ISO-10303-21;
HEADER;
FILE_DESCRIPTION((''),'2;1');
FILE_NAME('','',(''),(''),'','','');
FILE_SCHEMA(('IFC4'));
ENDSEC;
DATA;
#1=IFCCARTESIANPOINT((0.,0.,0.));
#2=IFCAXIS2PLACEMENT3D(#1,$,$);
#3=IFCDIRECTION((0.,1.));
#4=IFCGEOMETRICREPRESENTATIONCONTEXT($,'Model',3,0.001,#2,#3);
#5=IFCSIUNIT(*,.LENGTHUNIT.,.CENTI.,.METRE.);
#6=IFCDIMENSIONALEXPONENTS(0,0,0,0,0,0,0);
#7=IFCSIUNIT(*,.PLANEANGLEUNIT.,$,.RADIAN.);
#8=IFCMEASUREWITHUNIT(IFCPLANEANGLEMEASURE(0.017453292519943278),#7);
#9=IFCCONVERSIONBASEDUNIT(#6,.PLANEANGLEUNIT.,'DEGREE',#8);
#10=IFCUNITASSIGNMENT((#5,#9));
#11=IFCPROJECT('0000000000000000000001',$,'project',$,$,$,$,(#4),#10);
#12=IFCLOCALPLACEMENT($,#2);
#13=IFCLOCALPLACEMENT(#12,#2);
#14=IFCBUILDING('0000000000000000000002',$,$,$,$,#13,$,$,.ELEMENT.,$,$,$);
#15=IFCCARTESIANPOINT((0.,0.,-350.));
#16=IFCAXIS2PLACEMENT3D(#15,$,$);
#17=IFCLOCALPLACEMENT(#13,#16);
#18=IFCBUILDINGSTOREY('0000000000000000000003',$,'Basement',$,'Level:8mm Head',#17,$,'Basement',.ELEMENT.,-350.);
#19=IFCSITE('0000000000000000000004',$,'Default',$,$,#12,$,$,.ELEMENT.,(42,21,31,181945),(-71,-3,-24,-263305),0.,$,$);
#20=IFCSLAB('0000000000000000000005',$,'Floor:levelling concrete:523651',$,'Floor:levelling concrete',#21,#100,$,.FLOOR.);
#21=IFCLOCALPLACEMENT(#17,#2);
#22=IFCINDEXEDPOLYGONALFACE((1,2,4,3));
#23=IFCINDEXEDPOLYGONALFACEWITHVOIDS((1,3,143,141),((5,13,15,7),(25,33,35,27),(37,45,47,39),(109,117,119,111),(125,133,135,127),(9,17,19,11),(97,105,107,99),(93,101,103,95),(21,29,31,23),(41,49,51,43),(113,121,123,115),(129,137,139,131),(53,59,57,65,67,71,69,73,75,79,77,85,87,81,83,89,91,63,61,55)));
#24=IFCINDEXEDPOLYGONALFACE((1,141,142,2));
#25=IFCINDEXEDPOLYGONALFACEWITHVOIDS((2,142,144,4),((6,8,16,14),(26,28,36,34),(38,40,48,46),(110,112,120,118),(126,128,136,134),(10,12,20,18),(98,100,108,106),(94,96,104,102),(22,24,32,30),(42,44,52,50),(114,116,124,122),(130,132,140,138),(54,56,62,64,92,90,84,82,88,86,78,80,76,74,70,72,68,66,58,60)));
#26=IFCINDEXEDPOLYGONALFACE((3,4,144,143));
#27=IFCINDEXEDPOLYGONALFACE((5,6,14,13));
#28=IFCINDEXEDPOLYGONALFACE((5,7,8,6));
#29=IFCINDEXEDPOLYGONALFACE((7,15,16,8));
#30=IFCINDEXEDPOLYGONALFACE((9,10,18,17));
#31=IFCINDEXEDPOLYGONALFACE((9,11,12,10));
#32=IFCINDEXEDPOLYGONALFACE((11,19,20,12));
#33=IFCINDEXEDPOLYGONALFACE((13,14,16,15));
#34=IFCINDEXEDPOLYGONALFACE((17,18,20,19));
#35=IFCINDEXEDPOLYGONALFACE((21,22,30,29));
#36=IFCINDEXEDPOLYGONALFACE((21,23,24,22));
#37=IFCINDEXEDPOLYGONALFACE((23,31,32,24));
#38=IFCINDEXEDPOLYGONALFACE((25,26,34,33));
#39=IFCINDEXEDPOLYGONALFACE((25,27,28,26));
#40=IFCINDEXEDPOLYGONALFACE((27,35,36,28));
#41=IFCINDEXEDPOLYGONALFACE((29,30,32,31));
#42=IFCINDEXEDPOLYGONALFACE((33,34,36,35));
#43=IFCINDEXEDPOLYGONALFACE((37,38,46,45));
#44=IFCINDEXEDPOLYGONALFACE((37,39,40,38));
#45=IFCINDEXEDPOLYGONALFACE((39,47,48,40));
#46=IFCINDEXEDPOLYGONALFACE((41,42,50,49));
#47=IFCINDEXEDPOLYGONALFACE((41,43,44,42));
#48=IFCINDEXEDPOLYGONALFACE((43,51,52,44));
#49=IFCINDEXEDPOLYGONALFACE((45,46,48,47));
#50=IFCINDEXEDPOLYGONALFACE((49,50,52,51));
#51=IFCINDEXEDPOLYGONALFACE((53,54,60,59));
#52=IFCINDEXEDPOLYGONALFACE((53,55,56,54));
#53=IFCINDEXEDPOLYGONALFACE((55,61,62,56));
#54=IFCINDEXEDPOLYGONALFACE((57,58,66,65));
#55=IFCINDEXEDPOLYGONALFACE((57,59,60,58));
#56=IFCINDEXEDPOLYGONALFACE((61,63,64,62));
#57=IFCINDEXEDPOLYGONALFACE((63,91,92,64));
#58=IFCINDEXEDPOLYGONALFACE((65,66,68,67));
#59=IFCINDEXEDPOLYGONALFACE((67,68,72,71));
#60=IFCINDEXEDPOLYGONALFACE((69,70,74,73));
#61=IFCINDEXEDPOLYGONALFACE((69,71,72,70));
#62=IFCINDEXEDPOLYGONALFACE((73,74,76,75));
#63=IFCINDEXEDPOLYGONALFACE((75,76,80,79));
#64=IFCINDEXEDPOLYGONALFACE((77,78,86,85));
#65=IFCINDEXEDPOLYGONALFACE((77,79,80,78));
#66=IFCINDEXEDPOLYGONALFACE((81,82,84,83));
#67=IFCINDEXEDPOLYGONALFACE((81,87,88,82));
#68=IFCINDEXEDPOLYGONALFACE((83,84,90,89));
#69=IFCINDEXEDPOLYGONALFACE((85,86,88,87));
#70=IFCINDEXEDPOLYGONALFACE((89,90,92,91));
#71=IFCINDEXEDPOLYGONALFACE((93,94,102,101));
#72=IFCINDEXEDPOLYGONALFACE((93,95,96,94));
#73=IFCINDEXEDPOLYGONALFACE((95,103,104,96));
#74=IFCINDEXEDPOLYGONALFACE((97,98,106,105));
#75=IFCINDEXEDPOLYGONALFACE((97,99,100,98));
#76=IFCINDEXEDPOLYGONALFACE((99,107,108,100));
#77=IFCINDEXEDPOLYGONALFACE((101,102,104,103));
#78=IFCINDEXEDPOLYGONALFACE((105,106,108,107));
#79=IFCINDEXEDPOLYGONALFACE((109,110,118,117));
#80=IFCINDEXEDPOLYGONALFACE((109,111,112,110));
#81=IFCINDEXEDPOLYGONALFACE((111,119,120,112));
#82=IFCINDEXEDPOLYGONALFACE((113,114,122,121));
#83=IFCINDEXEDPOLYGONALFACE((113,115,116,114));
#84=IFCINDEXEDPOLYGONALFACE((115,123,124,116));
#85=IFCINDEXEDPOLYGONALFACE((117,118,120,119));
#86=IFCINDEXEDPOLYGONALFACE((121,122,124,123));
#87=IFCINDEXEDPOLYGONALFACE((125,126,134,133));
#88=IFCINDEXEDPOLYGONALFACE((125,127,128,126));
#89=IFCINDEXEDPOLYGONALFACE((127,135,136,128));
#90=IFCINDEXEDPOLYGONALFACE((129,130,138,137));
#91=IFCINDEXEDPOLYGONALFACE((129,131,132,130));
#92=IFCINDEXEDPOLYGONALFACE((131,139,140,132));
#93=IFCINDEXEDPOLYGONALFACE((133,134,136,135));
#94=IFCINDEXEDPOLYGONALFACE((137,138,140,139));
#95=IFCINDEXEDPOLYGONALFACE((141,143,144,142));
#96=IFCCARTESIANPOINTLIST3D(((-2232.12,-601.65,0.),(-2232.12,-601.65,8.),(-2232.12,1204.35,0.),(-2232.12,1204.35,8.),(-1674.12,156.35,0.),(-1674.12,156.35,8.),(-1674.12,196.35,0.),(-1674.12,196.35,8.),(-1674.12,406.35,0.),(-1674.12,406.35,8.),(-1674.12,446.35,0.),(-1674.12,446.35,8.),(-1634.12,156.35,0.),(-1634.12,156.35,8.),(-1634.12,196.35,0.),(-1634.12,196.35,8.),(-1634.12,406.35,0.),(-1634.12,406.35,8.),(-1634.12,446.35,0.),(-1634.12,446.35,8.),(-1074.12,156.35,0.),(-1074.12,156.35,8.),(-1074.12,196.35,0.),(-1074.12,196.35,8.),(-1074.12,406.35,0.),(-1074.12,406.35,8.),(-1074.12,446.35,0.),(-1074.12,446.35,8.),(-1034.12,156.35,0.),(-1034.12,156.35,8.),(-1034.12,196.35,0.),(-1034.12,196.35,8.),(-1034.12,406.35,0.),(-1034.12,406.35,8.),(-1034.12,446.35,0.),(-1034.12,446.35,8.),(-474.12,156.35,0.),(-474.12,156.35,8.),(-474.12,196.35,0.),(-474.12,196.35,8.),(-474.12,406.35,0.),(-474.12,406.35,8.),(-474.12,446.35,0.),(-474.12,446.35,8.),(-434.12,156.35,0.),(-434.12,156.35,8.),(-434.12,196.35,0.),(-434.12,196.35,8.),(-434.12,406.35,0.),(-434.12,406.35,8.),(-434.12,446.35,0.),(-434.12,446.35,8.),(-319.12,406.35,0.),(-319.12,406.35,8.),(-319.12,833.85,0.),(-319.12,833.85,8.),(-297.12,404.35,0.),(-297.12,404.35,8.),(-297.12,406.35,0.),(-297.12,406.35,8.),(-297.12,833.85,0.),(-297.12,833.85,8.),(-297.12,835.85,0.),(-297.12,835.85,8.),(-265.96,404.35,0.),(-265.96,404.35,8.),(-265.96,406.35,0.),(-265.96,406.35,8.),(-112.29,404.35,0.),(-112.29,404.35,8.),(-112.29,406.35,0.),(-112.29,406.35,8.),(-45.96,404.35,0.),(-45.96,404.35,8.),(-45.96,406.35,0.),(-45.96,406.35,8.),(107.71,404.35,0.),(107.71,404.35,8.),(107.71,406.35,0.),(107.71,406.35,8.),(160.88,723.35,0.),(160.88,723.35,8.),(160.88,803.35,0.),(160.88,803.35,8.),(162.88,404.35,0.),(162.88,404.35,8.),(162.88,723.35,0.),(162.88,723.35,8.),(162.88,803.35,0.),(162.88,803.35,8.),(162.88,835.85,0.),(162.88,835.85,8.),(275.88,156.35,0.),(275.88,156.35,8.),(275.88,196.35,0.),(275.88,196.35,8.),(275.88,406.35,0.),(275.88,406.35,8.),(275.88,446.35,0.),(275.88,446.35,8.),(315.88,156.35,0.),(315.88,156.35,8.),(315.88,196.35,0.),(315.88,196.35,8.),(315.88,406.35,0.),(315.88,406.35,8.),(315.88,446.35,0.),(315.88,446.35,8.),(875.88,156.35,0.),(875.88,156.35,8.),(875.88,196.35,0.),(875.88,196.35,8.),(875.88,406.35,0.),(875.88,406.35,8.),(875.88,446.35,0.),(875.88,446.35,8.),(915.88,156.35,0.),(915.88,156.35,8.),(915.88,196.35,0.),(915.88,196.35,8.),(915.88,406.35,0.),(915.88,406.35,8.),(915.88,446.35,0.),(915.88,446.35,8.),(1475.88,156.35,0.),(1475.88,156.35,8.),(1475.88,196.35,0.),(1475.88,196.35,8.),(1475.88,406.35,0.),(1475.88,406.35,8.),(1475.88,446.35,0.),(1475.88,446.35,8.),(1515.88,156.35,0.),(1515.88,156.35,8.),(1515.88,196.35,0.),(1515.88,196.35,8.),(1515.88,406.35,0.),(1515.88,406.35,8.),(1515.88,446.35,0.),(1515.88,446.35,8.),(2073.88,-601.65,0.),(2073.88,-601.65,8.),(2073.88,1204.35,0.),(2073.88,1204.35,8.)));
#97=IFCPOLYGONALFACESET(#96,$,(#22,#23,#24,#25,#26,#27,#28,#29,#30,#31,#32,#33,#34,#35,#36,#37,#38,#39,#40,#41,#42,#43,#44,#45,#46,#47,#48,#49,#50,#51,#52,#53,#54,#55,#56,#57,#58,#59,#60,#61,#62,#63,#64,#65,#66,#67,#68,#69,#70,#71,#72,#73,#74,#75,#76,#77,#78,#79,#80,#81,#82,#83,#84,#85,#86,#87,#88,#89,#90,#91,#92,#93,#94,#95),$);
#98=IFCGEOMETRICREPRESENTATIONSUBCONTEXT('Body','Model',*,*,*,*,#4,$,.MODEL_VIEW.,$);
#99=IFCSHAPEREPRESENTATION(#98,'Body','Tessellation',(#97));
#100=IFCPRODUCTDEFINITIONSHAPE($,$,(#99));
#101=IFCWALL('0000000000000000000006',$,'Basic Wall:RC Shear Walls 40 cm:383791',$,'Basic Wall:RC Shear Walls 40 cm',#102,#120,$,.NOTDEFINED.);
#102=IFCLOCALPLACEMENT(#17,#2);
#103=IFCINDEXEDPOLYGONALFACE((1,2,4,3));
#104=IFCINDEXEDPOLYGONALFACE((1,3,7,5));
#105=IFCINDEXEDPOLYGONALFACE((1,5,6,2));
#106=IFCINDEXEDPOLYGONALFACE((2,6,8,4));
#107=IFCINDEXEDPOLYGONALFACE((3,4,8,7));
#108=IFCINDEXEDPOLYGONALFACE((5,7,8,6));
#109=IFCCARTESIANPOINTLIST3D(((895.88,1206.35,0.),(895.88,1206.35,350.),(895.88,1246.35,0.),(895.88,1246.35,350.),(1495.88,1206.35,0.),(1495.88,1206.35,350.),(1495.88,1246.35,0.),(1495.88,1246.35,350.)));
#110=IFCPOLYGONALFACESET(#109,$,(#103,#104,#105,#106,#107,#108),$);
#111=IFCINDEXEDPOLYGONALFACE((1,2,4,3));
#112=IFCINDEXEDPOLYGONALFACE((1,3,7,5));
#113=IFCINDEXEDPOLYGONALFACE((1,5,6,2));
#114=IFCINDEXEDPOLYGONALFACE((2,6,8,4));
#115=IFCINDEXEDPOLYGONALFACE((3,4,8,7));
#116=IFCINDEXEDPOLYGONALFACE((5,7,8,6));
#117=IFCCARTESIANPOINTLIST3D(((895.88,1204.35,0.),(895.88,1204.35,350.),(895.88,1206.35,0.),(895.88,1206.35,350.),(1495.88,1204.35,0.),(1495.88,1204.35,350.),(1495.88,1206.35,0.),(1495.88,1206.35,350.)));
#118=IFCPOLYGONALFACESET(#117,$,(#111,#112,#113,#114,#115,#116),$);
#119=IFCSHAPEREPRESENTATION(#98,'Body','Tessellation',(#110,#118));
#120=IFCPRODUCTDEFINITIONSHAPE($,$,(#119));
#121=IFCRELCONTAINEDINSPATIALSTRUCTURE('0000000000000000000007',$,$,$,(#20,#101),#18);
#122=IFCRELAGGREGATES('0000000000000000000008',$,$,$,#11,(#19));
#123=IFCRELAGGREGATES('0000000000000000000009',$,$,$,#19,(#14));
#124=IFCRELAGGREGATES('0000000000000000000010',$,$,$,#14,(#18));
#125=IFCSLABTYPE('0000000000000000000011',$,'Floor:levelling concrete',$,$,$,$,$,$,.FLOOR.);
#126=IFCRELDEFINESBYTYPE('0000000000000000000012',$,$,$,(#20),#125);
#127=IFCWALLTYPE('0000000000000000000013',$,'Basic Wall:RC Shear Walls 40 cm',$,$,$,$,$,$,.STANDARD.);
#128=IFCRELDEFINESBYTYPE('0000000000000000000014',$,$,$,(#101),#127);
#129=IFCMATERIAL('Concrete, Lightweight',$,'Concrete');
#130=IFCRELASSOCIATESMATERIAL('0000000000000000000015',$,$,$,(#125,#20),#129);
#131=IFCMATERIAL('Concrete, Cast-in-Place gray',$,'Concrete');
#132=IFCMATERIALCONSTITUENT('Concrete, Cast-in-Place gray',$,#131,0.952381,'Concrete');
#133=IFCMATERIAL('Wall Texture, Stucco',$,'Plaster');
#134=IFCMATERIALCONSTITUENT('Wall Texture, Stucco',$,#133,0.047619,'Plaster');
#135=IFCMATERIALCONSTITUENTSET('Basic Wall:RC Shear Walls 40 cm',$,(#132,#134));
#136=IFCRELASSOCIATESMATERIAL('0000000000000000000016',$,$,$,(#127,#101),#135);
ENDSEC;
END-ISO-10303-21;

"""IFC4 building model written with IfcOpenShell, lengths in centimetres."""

from ifc_helpers import new_model, entity, si_unit, converted_unit, direction, frame, origin, place, context, subcontext, project, spatial, indexed_curve, outline, extrude, material, constituent, constituent_set, type_object, element, save


model = new_model("IFC4")

# Units and contexts
model_context = context("Model", 3, precision=0.001, world=origin(), true_north=direction((0.0, 1.0)))
body_context = subcontext(model_context, "Body", "Model", "MODEL_VIEW")
ifc_project = project(units=[si_unit("LENGTHUNIT", "METRE", prefix="CENTI"), converted_unit("PLANEANGLEUNIT", "DEGREE", entity("IfcPlaneAngleMeasure", 0.017453292519943278), si_unit("PLANEANGLEUNIT", "RADIAN"), dimensions=[0, 0, 0, 0, 0, 0, 0])], contexts=[model_context])

# Site, building, storey
site_placement = place(None, origin())
site = spatial("IfcSite", under=ifc_project, at=site_placement, Name="Default", CompositionType="ELEMENT", RefLatitude=(42, 21, 31, 181945), RefLongitude=(-71, -3, -24, -263305), RefElevation=0.0)
building_placement = place(site_placement, origin())
building = spatial("IfcBuilding", under=site, at=building_placement, CompositionType="ELEMENT")
storey_placement = place(building_placement, frame((0.0, 0.0, -350.0)))
storey = spatial("IfcBuildingStorey", under=building, at=storey_placement, Name="Basement", ObjectType="Level:8mm Head", LongName="Basement", CompositionType="ELEMENT", Elevation=-350.0)

# Shared definitions
ifc_material_1 = material(Name="Concrete, Cast-in-Place gray", Category="Concrete")

# Slab, openings
ifc_material_2 = material(Name="Concrete, Lightweight", Category="Concrete")
slab_type_1 = type_object("IfcSlabType", Name="Floor:levelling concrete", PredefinedType="FLOOR", material=ifc_material_2)
slab_1_placement = place(storey_placement, origin())
slab_1 = element("IfcSlab", 1, at=slab_1_placement, inside=storey, type_object=slab_type_1, material=ifc_material_2, Name="Floor:levelling concrete:523651", ObjectType="Floor:levelling concrete", PredefinedType="FLOOR", context=body_context, shape_type="SweptSolid", body=[
    extrude(outline(indexed_curve([(-2153.0, -913.0), (-1575.0, -913.0), (-975.0, -913.0), (-375.0, -913.0), (375.0, -913.0), (975.0, -913.0), (1575.0, -913.0), (2153.0, -913.0), (2153.0, -85.0), (2153.0, 165.0), (2153.0, 893.0), (1575.0, 893.0), (975.0, 893.0), (375.0, 893.0), (-375.0, 893.0), (-975.0, 893.0), (-1575.0, 893.0), (-2153.0, 893.0), (-2153.0, 165.0), (-2153.0, -85.0), (-2153.0, -913.0)], self_intersect=False), holes=[indexed_curve([(-395.0, 95.0), (-395.0, 135.0), (-355.0, 135.0), (-355.0, 95.0), (-395.0, 95.0)], self_intersect=False), indexed_curve([(-395.0, -155.0), (-395.0, -115.0), (-355.0, -115.0), (-355.0, -155.0), (-395.0, -155.0)], self_intersect=False), indexed_curve([(-995.0, 95.0), (-995.0, 135.0), (-955.0, 135.0), (-955.0, 95.0), (-995.0, 95.0)], self_intersect=False), indexed_curve([(-995.0, -155.0), (-995.0, -115.0), (-955.0, -115.0), (-955.0, -155.0), (-995.0, -155.0)], self_intersect=False), indexed_curve([(-1595.0, 95.0), (-1595.0, 135.0), (-1555.0, 135.0), (-1555.0, 95.0), (-1595.0, 95.0)], self_intersect=False), indexed_curve([(-1595.0, -155.0), (-1595.0, -115.0), (-1555.0, -115.0), (-1555.0, -155.0), (-1595.0, -155.0)], self_intersect=False), indexed_curve([(1555.0, 95.0), (1555.0, 135.0), (1595.0, 135.0), (1595.0, 95.0), (1555.0, 95.0)], self_intersect=False), indexed_curve([(1555.0, -155.0), (1555.0, -115.0), (1595.0, -115.0), (1595.0, -155.0), (1555.0, -155.0)], self_intersect=False), indexed_curve([(955.0, 95.0), (955.0, 135.0), (995.0, 135.0), (995.0, 95.0), (955.0, 95.0)], self_intersect=False), indexed_curve([(955.0, -155.0), (955.0, -115.0), (995.0, -115.0), (995.0, -155.0), (955.0, -155.0)], self_intersect=False), indexed_curve([(355.0, 95.0), (355.0, 135.0), (395.0, 135.0), (395.0, 95.0), (355.0, 95.0)], self_intersect=False), indexed_curve([(355.0, -155.0), (355.0, -115.0), (395.0, -115.0), (395.0, -155.0), (355.0, -155.0)], self_intersect=False), indexed_curve([(-186.84, -113.0), (-186.84, -115.0), (-33.16, -115.0), (-33.16, -113.0), (33.17, -113.0), (33.17, -115.0), (186.83, -115.0), (186.83, -113.0), (218.0, -113.0), (218.0, -115.0), (240.0, -115.0), (240.0, -542.5), (218.0, -542.5), (218.0, -544.5), (-218.0, -544.5), (-242.0, -544.5), (-242.0, -512.0), (-240.0, -512.0), (-240.0, -432.0), (-242.0, -432.0), (-242.0, -137.0), (-242.0, -113.0), (-186.84, -113.0)], self_intersect=False)]), frame((-79.12, 291.35, 0.0), z_axis=(0.0, 0.0, 1.0), x_axis=(-1.0, 0.0, 0.0)), (0.0, 0.0, 1.0), 8.0),
])
opening_1_placement = place(slab_1_placement, origin())
element("IfcOpeningElement", 2, at=opening_1_placement, cuts=slab_1, PredefinedType="OPENING", context=body_context, shape_type="SweptSolid", body=[
    extrude(outline(indexed_curve([(-1634.12, 196.35), (-1674.12, 196.35), (-1674.12, 156.35), (-1634.12, 156.35), (-1634.12, 196.35)], self_intersect=False)), frame((0.0, 0.0, 350.0)), (0.0, 0.0, -1.0), 1806.0),
])
opening_2_placement = place(slab_1_placement, origin())
element("IfcOpeningElement", 3, at=opening_2_placement, cuts=slab_1, PredefinedType="OPENING", context=body_context, shape_type="SweptSolid", body=[
    extrude(outline(indexed_curve([(-1634.12, 446.35), (-1674.12, 446.35), (-1674.12, 406.35), (-1634.12, 406.35), (-1634.12, 446.35)], self_intersect=False)), frame((0.0, 0.0, 350.0)), (0.0, 0.0, -1.0), 1806.0),
])
opening_3_placement = place(slab_1_placement, origin())
element("IfcOpeningElement", 4, at=opening_3_placement, cuts=slab_1, PredefinedType="OPENING", context=body_context, shape_type="SweptSolid", body=[
    extrude(outline(indexed_curve([(-1034.12, 196.35), (-1074.12, 196.35), (-1074.12, 156.35), (-1034.12, 156.35), (-1034.12, 196.35)], self_intersect=False)), frame((0.0, 0.0, 350.0)), (0.0, 0.0, -1.0), 1806.0),
])
opening_4_placement = place(slab_1_placement, origin())
element("IfcOpeningElement", 5, at=opening_4_placement, cuts=slab_1, PredefinedType="OPENING", context=body_context, shape_type="SweptSolid", body=[
    extrude(outline(indexed_curve([(-1034.12, 446.35), (-1074.12, 446.35), (-1074.12, 406.35), (-1034.12, 406.35), (-1034.12, 446.35)], self_intersect=False)), frame((0.0, 0.0, 350.0)), (0.0, 0.0, -1.0), 1806.0),
])
opening_5_placement = place(slab_1_placement, origin())
element("IfcOpeningElement", 6, at=opening_5_placement, cuts=slab_1, PredefinedType="OPENING", context=body_context, shape_type="SweptSolid", body=[
    extrude(outline(indexed_curve([(-434.12, 196.35), (-474.12, 196.35), (-474.12, 156.35), (-434.12, 156.35), (-434.12, 196.35)], self_intersect=False)), frame((0.0, 0.0, 350.0)), (0.0, 0.0, -1.0), 1806.0),
])
opening_6_placement = place(slab_1_placement, origin())
element("IfcOpeningElement", 7, at=opening_6_placement, cuts=slab_1, PredefinedType="OPENING", context=body_context, shape_type="SweptSolid", body=[
    extrude(outline(indexed_curve([(-434.12, 446.35), (-474.12, 446.35), (-474.12, 406.35), (-434.12, 406.35), (-434.12, 446.35)], self_intersect=False)), frame((0.0, 0.0, 350.0)), (0.0, 0.0, -1.0), 1806.0),
])
opening_7_placement = place(slab_1_placement, origin())
element("IfcOpeningElement", 8, at=opening_7_placement, cuts=slab_1, PredefinedType="OPENING", context=body_context, shape_type="SweptSolid", body=[
    extrude(outline(indexed_curve([(315.88, 196.35), (275.88, 196.35), (275.88, 156.35), (315.88, 156.35), (315.88, 196.35)], self_intersect=False)), frame((0.0, 0.0, 350.0)), (0.0, 0.0, -1.0), 1806.0),
])
opening_8_placement = place(slab_1_placement, origin())
element("IfcOpeningElement", 9, at=opening_8_placement, cuts=slab_1, PredefinedType="OPENING", context=body_context, shape_type="SweptSolid", body=[
    extrude(outline(indexed_curve([(315.88, 446.35), (275.88, 446.35), (275.88, 406.35), (315.88, 406.35), (315.88, 446.35)], self_intersect=False)), frame((0.0, 0.0, 350.0)), (0.0, 0.0, -1.0), 1806.0),
])
opening_9_placement = place(slab_1_placement, origin())
element("IfcOpeningElement", 10, at=opening_9_placement, cuts=slab_1, PredefinedType="OPENING", context=body_context, shape_type="SweptSolid", body=[
    extrude(outline(indexed_curve([(915.88, 196.35), (875.88, 196.35), (875.88, 156.35), (915.88, 156.35), (915.88, 196.35)], self_intersect=False)), frame((0.0, 0.0, 350.0)), (0.0, 0.0, -1.0), 1806.0),
])
opening_10_placement = place(slab_1_placement, origin())
element("IfcOpeningElement", 11, at=opening_10_placement, cuts=slab_1, PredefinedType="OPENING", context=body_context, shape_type="SweptSolid", body=[
    extrude(outline(indexed_curve([(915.88, 446.35), (875.88, 446.35), (875.88, 406.35), (915.88, 406.35), (915.88, 446.35)], self_intersect=False)), frame((0.0, 0.0, 350.0)), (0.0, 0.0, -1.0), 1806.0),
])
opening_11_placement = place(slab_1_placement, origin())
element("IfcOpeningElement", 12, at=opening_11_placement, cuts=slab_1, PredefinedType="OPENING", context=body_context, shape_type="SweptSolid", body=[
    extrude(outline(indexed_curve([(1515.88, 196.35), (1475.88, 196.35), (1475.88, 156.35), (1515.88, 156.35), (1515.88, 196.35)], self_intersect=False)), frame((0.0, 0.0, 350.0)), (0.0, 0.0, -1.0), 1806.0),
])
opening_12_placement = place(slab_1_placement, origin())
element("IfcOpeningElement", 13, at=opening_12_placement, cuts=slab_1, PredefinedType="OPENING", context=body_context, shape_type="SweptSolid", body=[
    extrude(outline(indexed_curve([(1515.88, 446.35), (1475.88, 446.35), (1475.88, 406.35), (1515.88, 406.35), (1515.88, 446.35)], self_intersect=False)), frame((0.0, 0.0, 350.0)), (0.0, 0.0, -1.0), 1806.0),
])
opening_13_placement = place(slab_1_placement, origin())
element("IfcOpeningElement", 14, at=opening_13_placement, cuts=slab_1, PredefinedType="OPENING", context=body_context, shape_type="SweptSolid", body=[
    extrude(outline(indexed_curve([(160.88, 833.85), (-319.12, 833.85), (-319.12, 406.35), (160.88, 406.35), (160.88, 833.85)], self_intersect=False)), frame((0.0, 0.0, 350.0)), (0.0, 0.0, -1.0), 1806.0),
])

# Wall
ifc_constituent_1 = constituent(ifc_material_1, Name="Concrete, Cast-in-Place gray", Category="Concrete", fraction=0.952381)
ifc_material_3 = material(Name="Wall Texture, Stucco", Category="Plaster")
ifc_constituent_2 = constituent(ifc_material_3, Name="Wall Texture, Stucco", Category="Plaster", fraction=0.047619)
ifc_constituent_set_1 = constituent_set(constituents=[ifc_constituent_1, ifc_constituent_2], Name="Basic Wall:RC Shear Walls 40 cm")
wall_type_1 = type_object("IfcWallType", Name="Basic Wall:RC Shear Walls 40 cm", PredefinedType="STANDARD", material=ifc_constituent_set_1)
wall_1_placement = place(storey_placement, frame((895.88, 1225.35, 0.0)))
element("IfcWall", 15, at=wall_1_placement, inside=storey, type_object=wall_type_1, material=ifc_constituent_set_1, Name="Basic Wall:RC Shear Walls 40 cm:383791", ObjectType="Basic Wall:RC Shear Walls 40 cm", PredefinedType="NOTDEFINED", context=body_context, shape_type="SweptSolid", body=[
    extrude(outline(indexed_curve([(-20.0, -300.0), (20.0, -300.0), (20.0, 300.0), (-20.0, 300.0), (-20.0, -300.0)], self_intersect=False)), frame((300.0, 1.0, 0.0), z_axis=(0.0, 0.0, 1.0), x_axis=(0.0, -1.0, 0.0)), (0.0, 0.0, 1.0), 350.0),
    extrude(outline(indexed_curve([(-1.0, -300.0), (1.0, -300.0), (1.0, 300.0), (-1.0, 300.0), (-1.0, -300.0)], self_intersect=False)), frame((300.0, -20.0, 0.0), z_axis=(0.0, 0.0, 1.0), x_axis=(0.0, 1.0, 0.0)), (0.0, 0.0, 1.0), 350.0),
])

save(model, "model.ifc")
